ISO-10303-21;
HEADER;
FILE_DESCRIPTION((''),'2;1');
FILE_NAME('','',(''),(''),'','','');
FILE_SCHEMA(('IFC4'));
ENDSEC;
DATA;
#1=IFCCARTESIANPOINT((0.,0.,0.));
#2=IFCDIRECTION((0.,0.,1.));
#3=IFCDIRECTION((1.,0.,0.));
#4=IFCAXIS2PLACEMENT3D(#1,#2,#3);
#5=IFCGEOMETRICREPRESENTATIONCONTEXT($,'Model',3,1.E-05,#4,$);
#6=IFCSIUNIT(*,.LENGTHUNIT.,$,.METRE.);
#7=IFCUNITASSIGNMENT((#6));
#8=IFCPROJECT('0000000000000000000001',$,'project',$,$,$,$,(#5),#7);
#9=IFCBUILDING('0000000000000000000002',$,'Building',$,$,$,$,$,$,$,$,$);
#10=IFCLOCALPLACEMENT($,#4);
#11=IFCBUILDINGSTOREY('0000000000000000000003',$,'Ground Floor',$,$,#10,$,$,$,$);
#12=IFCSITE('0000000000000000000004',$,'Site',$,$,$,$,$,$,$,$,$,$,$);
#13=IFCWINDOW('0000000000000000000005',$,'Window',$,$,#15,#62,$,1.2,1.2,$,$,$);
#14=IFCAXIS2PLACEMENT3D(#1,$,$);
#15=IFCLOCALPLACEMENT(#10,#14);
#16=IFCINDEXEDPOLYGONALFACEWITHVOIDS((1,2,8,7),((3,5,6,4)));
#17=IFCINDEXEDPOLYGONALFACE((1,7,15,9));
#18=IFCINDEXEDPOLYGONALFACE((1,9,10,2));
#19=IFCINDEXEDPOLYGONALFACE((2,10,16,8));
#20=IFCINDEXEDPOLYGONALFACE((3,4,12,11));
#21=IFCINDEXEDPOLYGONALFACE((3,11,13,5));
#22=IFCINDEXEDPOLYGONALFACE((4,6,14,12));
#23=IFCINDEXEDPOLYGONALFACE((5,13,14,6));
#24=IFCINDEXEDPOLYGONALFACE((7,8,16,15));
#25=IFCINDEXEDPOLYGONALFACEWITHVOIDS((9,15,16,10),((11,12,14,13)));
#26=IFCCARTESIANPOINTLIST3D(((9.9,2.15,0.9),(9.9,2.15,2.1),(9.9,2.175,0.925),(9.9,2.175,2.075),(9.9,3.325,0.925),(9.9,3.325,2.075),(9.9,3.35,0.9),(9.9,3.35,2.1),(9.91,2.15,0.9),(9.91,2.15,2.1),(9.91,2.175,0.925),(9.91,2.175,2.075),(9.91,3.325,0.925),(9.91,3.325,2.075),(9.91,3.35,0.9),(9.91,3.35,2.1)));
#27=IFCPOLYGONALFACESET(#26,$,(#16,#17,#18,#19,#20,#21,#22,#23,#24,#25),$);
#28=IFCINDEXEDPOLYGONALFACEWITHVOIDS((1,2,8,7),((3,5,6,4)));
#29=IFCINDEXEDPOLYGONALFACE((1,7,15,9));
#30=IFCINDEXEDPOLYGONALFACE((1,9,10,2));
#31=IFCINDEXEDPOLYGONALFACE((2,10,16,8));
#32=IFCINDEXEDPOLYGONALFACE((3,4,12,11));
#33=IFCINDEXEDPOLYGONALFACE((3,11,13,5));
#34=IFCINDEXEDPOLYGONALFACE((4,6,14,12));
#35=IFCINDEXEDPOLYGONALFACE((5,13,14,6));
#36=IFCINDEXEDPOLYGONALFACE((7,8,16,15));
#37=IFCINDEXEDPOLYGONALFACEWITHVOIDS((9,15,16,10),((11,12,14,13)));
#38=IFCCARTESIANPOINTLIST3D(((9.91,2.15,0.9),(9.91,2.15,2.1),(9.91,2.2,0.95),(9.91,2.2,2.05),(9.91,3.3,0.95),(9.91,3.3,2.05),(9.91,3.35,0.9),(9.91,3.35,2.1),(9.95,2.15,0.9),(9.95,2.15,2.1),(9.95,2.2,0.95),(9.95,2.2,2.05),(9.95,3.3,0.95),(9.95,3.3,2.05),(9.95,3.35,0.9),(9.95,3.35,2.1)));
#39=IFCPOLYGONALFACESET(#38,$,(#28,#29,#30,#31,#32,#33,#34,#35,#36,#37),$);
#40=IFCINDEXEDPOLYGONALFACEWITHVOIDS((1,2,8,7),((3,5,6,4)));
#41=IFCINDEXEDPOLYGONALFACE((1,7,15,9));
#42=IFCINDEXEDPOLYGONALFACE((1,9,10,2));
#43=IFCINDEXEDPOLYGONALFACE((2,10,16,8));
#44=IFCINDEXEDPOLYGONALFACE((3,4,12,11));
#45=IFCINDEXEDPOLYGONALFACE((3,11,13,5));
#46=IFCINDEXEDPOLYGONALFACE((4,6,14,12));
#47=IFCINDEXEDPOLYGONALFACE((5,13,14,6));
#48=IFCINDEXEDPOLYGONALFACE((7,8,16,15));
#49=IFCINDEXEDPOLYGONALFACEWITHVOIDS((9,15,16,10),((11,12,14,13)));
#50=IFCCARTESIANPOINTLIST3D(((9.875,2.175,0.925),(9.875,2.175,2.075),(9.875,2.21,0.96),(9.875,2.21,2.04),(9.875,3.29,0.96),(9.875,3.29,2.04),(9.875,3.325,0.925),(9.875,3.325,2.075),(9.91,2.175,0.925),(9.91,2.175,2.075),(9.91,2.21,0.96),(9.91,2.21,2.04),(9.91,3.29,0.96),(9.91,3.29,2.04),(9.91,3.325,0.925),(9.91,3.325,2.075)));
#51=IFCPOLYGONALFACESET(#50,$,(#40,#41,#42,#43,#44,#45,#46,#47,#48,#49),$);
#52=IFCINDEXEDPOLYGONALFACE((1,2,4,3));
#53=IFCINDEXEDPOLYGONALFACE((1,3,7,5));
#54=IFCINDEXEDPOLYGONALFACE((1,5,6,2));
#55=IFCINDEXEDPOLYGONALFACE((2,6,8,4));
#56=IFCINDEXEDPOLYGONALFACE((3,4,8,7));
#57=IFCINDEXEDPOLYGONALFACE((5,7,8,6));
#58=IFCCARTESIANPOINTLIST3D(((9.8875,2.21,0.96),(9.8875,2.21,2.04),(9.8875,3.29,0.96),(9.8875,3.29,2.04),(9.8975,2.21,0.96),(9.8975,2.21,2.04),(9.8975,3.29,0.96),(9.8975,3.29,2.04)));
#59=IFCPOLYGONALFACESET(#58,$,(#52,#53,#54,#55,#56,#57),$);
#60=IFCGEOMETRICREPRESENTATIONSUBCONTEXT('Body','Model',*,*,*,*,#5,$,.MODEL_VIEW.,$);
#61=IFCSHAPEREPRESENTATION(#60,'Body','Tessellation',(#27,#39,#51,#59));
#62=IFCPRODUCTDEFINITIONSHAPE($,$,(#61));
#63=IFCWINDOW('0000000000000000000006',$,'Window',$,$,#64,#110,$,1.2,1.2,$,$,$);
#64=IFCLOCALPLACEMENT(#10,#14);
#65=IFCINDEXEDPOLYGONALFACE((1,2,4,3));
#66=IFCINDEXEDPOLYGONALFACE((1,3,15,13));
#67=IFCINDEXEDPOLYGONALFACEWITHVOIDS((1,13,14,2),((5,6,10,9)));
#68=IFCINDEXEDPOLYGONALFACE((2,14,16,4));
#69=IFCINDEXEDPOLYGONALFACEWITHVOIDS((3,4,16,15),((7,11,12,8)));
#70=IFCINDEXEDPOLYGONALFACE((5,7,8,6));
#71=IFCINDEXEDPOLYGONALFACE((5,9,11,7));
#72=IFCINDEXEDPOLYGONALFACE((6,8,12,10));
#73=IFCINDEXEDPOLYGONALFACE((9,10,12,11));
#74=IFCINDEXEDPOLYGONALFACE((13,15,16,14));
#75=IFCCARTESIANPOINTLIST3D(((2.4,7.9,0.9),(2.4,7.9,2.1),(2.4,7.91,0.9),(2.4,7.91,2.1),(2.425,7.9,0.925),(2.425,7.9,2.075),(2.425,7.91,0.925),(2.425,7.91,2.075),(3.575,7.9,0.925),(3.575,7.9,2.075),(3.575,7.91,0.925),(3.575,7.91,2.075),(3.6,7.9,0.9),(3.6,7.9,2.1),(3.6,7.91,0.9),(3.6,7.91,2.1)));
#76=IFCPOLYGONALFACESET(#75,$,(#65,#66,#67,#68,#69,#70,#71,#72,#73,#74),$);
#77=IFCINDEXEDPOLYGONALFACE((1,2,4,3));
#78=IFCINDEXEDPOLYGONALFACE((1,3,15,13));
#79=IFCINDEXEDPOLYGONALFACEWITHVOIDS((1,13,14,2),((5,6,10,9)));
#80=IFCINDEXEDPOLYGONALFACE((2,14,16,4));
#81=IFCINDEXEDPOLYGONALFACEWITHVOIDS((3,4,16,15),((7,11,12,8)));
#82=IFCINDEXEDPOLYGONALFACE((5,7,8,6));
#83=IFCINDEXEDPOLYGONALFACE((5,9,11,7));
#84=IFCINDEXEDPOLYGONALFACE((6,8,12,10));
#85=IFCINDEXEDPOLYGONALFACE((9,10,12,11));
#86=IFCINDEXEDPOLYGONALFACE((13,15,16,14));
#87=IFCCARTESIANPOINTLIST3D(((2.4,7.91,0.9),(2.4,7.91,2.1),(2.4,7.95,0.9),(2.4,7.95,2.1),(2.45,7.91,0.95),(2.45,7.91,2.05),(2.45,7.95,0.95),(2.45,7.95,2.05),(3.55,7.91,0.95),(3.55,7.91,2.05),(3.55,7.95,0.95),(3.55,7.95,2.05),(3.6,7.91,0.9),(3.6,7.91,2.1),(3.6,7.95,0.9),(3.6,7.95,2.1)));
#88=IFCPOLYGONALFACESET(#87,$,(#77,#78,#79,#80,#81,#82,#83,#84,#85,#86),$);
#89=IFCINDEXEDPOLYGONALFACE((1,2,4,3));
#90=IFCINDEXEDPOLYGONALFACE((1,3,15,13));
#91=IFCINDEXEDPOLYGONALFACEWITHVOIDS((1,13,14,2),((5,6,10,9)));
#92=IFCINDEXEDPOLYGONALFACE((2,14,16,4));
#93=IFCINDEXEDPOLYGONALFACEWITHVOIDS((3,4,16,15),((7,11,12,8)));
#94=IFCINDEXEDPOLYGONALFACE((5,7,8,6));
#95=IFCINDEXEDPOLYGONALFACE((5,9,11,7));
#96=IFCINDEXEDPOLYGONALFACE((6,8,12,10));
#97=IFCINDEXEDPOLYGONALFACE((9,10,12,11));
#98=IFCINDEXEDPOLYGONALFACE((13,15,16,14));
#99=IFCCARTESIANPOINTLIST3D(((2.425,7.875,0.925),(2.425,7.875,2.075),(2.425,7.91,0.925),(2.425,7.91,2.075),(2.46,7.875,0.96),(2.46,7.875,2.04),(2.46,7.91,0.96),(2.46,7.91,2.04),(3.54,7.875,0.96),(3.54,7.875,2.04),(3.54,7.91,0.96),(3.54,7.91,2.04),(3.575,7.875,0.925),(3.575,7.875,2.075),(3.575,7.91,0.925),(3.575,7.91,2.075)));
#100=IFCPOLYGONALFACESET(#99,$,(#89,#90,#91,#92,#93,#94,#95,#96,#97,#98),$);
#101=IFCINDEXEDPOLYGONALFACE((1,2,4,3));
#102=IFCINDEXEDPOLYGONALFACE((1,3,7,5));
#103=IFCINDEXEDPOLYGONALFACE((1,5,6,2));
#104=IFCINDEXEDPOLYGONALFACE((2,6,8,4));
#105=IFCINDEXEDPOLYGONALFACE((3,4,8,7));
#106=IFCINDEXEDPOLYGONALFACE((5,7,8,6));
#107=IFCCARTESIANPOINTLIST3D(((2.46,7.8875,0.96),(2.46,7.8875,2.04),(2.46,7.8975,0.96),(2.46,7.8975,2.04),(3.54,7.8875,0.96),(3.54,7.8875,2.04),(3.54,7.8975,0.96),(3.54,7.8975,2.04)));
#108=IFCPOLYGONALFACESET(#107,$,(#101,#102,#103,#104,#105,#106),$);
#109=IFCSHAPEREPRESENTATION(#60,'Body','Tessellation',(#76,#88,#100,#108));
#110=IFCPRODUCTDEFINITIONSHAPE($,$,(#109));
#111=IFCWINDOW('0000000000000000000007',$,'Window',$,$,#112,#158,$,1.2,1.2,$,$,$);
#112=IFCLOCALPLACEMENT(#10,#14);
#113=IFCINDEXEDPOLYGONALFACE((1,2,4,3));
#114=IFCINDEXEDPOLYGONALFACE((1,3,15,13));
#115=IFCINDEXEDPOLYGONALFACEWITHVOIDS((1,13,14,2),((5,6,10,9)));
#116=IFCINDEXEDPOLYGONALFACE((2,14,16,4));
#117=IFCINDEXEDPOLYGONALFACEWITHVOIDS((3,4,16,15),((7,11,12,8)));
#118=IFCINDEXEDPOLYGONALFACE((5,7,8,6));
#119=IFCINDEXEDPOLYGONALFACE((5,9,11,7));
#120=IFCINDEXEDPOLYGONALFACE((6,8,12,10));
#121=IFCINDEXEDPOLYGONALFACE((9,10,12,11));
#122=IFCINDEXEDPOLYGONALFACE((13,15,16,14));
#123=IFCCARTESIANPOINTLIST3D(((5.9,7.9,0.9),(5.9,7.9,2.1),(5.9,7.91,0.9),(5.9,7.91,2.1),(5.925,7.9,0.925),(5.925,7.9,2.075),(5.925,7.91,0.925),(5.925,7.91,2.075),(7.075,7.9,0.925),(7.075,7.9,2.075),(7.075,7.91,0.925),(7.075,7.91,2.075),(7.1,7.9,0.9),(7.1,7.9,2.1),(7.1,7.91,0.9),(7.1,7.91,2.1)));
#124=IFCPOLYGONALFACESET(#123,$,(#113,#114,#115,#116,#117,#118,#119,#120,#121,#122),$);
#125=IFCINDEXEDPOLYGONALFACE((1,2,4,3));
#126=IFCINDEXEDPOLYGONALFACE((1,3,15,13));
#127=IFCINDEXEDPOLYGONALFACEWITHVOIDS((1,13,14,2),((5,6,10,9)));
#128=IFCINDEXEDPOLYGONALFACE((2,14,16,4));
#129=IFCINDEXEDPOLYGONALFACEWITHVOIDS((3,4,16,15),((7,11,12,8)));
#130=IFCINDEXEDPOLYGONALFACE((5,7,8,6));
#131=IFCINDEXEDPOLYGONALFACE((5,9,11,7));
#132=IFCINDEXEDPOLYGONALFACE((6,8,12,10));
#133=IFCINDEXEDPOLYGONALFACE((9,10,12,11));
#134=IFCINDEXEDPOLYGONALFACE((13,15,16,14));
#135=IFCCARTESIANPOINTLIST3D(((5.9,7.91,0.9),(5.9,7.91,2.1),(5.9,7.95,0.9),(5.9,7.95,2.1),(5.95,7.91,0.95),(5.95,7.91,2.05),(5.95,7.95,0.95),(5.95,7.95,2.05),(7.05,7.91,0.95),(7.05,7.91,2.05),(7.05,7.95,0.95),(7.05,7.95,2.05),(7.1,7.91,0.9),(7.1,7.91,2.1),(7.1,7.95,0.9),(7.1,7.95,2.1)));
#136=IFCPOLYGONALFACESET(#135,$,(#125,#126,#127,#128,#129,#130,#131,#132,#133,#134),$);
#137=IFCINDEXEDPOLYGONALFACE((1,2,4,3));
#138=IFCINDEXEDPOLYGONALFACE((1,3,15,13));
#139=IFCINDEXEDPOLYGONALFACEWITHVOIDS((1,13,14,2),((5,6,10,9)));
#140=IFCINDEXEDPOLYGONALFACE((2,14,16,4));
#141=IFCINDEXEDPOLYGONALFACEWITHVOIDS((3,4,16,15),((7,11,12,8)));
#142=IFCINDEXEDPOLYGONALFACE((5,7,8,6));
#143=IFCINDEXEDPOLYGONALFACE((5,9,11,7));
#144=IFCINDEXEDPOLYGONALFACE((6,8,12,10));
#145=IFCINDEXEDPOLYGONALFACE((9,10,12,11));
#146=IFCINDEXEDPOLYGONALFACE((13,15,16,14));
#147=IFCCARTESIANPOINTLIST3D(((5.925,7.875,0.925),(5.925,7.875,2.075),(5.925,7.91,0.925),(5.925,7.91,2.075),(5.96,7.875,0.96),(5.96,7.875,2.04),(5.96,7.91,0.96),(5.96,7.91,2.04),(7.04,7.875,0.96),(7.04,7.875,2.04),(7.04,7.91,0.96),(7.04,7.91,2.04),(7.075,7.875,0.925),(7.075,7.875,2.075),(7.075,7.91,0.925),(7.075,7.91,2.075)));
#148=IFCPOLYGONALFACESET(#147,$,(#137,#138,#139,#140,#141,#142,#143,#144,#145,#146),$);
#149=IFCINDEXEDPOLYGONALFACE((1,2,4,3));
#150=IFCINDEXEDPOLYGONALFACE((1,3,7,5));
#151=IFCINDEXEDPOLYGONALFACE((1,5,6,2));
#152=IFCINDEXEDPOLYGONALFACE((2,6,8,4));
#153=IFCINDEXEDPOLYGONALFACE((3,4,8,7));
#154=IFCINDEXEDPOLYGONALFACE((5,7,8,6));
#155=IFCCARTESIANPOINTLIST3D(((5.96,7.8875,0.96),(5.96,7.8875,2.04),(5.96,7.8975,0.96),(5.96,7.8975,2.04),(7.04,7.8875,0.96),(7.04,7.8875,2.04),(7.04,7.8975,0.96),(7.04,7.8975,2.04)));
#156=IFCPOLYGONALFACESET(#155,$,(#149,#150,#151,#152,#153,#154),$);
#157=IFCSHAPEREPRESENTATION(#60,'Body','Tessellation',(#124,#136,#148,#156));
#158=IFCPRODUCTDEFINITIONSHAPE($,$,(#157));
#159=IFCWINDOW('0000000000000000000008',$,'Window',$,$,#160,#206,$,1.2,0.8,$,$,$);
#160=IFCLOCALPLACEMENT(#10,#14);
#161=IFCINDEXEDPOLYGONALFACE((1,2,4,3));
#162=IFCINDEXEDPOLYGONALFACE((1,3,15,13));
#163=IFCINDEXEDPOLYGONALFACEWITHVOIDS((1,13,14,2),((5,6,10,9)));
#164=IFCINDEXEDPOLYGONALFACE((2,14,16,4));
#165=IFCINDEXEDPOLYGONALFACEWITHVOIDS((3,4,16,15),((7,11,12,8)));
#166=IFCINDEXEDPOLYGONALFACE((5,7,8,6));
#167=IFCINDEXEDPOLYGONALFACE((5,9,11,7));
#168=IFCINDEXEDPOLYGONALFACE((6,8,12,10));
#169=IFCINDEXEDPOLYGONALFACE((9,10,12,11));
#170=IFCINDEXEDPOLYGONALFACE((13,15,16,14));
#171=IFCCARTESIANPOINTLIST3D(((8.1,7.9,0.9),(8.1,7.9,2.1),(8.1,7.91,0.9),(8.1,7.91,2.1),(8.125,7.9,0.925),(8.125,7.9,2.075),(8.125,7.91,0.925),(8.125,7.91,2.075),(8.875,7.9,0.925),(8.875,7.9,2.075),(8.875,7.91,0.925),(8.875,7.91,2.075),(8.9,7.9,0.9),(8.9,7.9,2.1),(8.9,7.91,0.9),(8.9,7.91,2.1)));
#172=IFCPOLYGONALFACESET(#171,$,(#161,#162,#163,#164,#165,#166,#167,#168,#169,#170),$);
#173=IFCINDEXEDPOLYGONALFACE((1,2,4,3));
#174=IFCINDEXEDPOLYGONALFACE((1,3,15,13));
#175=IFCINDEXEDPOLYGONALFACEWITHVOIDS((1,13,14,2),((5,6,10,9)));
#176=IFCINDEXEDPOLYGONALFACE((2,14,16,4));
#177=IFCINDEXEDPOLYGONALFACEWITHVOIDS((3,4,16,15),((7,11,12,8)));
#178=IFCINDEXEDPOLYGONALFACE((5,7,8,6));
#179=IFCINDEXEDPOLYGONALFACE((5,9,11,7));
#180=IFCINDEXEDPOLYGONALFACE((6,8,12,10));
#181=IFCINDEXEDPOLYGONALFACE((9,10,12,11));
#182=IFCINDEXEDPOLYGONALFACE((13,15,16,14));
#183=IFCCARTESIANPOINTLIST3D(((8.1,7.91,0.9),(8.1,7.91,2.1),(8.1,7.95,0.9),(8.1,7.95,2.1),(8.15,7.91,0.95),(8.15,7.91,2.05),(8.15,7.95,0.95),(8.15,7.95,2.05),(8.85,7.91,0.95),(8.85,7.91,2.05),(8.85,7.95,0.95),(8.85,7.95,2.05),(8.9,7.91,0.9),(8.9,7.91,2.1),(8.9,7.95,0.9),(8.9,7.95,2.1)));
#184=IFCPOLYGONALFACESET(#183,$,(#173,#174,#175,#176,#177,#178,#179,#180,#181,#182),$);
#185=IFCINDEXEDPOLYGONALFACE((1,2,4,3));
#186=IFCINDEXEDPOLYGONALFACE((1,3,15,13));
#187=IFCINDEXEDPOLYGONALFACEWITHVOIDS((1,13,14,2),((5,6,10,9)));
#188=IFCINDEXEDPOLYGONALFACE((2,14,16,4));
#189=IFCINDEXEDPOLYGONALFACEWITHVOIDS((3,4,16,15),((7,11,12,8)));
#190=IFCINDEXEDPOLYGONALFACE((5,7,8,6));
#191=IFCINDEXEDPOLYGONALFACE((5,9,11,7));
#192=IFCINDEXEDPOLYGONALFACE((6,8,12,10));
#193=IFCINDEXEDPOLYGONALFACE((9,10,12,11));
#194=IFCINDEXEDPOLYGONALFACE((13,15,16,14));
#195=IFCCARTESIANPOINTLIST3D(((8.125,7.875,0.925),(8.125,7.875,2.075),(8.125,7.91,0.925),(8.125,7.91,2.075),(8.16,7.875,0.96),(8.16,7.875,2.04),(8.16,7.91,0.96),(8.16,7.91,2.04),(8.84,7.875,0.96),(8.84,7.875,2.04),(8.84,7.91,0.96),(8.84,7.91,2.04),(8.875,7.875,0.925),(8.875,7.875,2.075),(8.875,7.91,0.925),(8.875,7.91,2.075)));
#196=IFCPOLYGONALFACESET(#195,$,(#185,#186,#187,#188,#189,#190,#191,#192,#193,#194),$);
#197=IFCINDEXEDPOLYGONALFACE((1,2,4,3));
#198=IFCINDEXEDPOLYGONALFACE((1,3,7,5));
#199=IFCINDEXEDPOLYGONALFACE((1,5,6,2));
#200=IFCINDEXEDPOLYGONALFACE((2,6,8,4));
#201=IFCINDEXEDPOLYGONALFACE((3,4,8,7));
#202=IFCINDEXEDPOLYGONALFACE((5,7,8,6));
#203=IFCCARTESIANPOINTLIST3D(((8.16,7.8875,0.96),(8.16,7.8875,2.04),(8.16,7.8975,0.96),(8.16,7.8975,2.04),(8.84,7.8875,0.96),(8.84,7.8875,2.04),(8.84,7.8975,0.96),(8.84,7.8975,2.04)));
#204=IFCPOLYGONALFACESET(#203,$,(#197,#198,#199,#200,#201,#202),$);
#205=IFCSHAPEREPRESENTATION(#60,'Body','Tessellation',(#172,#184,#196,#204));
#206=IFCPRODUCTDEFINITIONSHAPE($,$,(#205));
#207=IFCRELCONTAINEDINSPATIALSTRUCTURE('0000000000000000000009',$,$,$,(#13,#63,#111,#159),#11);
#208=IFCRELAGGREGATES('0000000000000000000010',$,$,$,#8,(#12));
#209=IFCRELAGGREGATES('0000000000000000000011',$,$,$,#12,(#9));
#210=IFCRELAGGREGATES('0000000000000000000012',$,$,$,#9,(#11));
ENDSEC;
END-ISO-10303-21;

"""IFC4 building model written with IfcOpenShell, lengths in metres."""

from ifc_helpers import new_model, si_unit, frame, origin_with_axes, place, context, subcontext, project, spatial, line, indexed_curve, outline, extrude, element, save


model = new_model("IFC4")

# Units and contexts
model_context = context("Model", 3, precision=1e-05, world=origin_with_axes())
body_context = subcontext(model_context, "Body", "Model", "MODEL_VIEW")
ifc_project = project(units=[si_unit("LENGTHUNIT", "METRE")], contexts=[model_context])

# Site, building, storey
site = spatial("IfcSite", under=ifc_project, Name="Site")
building = spatial("IfcBuilding", under=site, Name="Building")
storey_placement = place(None, origin_with_axes())
storey = spatial("IfcBuildingStorey", under=building, at=storey_placement, Name="Ground Floor")

# Windows
for number, where, z_axis, x_axis, name in (
    (1, (10.0, 2.15, 0.9), (0.0, 0.0, 1.0), (0.0, 1.0, 0.0), "Window"),
    (2, (3.6, 8.0, 0.9), (0.0, 0.0, 1.0), (-1.0, 0.0, 0.0), "Window"),
    (3, (7.1, 8.0, 0.9), (0.0, 0.0, 1.0), (-1.0, 0.0, 0.0), "Window"),
):
    element("IfcWindow", number, at=place(storey_placement, frame(where, z_axis=z_axis, x_axis=x_axis)), inside=storey, Name=name, OverallHeight=1.2, OverallWidth=1.2, context=body_context, shape_type="SweptSolid", body=[
        extrude(outline(indexed_curve([(0.0, 0.0), (1.2, 0.0), (1.2, 1.2), (0.0, 1.2)], segments=[line(1, 2, 3, 4, 1)]), holes=[indexed_curve([(0.025, 0.025), (1.175, 0.025), (1.175, 1.175), (0.025, 1.175)], segments=[line(1, 2, 3, 4, 1)])]), frame((0.0, 0.09, 0.0), z_axis=(0.0, -1.0, 0.0), x_axis=(1.0, 0.0, 0.0)), (0.0, 0.0, -1.0), 0.01),
        extrude(outline(indexed_curve([(0.0, 0.0), (1.2, 0.0), (1.2, 1.2), (0.0, 1.2)], segments=[line(1, 2, 3, 4, 1)]), holes=[indexed_curve([(0.05, 0.05), (1.15, 0.05), (1.15, 1.15), (0.05, 1.15)], segments=[line(1, 2, 3, 4, 1)])]), frame((0.0, 0.05, 0.0), z_axis=(0.0, -1.0, 0.0), x_axis=(1.0, 0.0, 0.0)), (0.0, 0.0, -1.0), 0.04),
        extrude(outline(indexed_curve([(0.0, 0.0), (1.15, 0.0), (1.15, 1.15), (0.0, 1.15)], segments=[line(1, 2, 3, 4, 1)]), holes=[indexed_curve([(0.035, 0.035), (1.115, 0.035), (1.115, 1.115), (0.035, 1.115)], segments=[line(1, 2, 3, 4, 1)])]), frame((0.025, 0.09, 0.025), z_axis=(0.0, -1.0, 0.0), x_axis=(1.0, 0.0, 0.0)), (0.0, 0.0, -1.0), 0.035),
        extrude(outline(indexed_curve([(0.035, 0.035), (1.115, 0.035), (1.115, 1.115), (0.035, 1.115)], segments=[line(1, 2, 3, 4, 1)])), frame((0.025, 0.1025, 0.025), z_axis=(0.0, -1.0, 0.0), x_axis=(1.0, 0.0, 0.0)), (0.0, 0.0, -1.0), 0.01),
    ])
window_1_placement = place(storey_placement, frame((8.9, 8.0, 0.9), z_axis=(0.0, 0.0, 1.0), x_axis=(-1.0, 0.0, 0.0)))
element("IfcWindow", 4, at=window_1_placement, inside=storey, Name="Window", OverallHeight=1.2, OverallWidth=0.8, context=body_context, shape_type="SweptSolid", body=[
    extrude(outline(indexed_curve([(0.0, 0.0), (0.8, 0.0), (0.8, 1.2), (0.0, 1.2)], segments=[line(1, 2, 3, 4, 1)]), holes=[indexed_curve([(0.025, 0.025), (0.775, 0.025), (0.775, 1.175), (0.025, 1.175)], segments=[line(1, 2, 3, 4, 1)])]), frame((0.0, 0.09, 0.0), z_axis=(0.0, -1.0, 0.0), x_axis=(1.0, 0.0, 0.0)), (0.0, 0.0, -1.0), 0.01),
    extrude(outline(indexed_curve([(0.0, 0.0), (0.8, 0.0), (0.8, 1.2), (0.0, 1.2)], segments=[line(1, 2, 3, 4, 1)]), holes=[indexed_curve([(0.05, 0.05), (0.75, 0.05), (0.75, 1.15), (0.05, 1.15)], segments=[line(1, 2, 3, 4, 1)])]), frame((0.0, 0.05, 0.0), z_axis=(0.0, -1.0, 0.0), x_axis=(1.0, 0.0, 0.0)), (0.0, 0.0, -1.0), 0.04),
    extrude(outline(indexed_curve([(0.0, 0.0), (0.75, 0.0), (0.75, 1.15), (0.0, 1.15)], segments=[line(1, 2, 3, 4, 1)]), holes=[indexed_curve([(0.035, 0.035), (0.715, 0.035), (0.715, 1.115), (0.035, 1.115)], segments=[line(1, 2, 3, 4, 1)])]), frame((0.025, 0.09, 0.025), z_axis=(0.0, -1.0, 0.0), x_axis=(1.0, 0.0, 0.0)), (0.0, 0.0, -1.0), 0.035),
    extrude(outline(indexed_curve([(0.035, 0.035), (0.715, 0.035), (0.715, 1.115), (0.035, 1.115)], segments=[line(1, 2, 3, 4, 1)])), frame((0.025, 0.1025, 0.025), z_axis=(0.0, -1.0, 0.0), x_axis=(1.0, 0.0, 0.0)), (0.0, 0.0, -1.0), 0.01),
])

save(model, "model.ifc")
